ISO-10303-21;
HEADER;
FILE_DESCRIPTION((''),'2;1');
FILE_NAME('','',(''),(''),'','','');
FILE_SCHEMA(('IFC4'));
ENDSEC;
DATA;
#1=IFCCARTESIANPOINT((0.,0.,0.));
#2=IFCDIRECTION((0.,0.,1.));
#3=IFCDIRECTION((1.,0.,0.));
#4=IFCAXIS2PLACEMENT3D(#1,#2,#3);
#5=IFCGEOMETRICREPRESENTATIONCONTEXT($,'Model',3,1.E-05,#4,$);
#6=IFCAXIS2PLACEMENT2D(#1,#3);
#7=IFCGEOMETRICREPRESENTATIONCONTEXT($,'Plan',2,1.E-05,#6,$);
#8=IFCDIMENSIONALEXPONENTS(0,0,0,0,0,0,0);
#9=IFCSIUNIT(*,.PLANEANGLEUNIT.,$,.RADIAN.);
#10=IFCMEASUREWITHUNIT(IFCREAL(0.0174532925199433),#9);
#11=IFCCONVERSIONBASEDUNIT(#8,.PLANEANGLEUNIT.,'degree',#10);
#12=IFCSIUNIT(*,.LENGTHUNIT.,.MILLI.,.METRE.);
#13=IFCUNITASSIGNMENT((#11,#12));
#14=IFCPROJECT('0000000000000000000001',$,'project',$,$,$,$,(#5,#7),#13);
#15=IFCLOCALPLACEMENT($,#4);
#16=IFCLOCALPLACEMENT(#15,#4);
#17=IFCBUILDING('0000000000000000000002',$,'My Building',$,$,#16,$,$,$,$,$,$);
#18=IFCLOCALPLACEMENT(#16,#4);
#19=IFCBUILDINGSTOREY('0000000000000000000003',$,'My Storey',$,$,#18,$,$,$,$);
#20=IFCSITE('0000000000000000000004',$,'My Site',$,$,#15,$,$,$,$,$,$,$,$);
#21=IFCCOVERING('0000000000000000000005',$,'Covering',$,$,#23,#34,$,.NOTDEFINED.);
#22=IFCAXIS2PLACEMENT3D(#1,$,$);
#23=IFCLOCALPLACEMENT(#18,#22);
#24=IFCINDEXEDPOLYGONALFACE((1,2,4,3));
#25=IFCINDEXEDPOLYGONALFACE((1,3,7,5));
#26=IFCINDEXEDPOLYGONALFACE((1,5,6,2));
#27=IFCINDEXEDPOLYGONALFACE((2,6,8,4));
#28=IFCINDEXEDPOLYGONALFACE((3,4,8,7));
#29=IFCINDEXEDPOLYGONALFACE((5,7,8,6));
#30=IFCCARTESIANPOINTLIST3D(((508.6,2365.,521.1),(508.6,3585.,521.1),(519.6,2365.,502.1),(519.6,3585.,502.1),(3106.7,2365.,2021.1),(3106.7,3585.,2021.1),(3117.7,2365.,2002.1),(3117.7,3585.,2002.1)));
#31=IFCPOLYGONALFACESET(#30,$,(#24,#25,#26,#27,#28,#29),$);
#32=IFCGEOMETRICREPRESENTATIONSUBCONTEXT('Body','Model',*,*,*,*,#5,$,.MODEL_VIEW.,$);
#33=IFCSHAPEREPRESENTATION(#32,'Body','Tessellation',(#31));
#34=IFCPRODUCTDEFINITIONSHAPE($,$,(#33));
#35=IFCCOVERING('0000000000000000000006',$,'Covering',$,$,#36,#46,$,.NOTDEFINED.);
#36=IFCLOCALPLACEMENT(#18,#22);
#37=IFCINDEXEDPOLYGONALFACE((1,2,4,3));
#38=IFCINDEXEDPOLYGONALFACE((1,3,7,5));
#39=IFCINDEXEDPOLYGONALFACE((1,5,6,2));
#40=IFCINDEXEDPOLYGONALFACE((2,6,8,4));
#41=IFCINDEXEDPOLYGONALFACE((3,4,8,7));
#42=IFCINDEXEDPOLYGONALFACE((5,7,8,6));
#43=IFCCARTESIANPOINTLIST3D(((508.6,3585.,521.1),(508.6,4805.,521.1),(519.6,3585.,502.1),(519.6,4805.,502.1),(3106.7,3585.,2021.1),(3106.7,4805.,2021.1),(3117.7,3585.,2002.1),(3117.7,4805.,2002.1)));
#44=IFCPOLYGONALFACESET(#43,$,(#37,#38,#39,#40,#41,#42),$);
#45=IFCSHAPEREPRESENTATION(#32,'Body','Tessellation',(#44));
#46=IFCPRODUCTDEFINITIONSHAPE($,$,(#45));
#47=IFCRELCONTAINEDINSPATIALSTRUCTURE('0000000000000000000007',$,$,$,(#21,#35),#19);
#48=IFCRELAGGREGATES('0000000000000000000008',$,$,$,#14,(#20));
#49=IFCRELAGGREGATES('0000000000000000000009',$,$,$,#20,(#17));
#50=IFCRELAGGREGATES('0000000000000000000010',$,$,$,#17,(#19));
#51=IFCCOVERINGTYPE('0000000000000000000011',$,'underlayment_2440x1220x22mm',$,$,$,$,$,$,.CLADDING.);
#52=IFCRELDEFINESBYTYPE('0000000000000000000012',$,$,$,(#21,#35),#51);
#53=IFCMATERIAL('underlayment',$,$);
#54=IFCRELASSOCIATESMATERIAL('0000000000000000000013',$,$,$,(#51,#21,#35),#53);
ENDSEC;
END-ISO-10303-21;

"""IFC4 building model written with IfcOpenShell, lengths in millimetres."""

from ifc_helpers import new_model, entity, si_unit, converted_unit, frame, frame_2d, origin_with_axes, place, context, subcontext, project, spatial, rectangle, extrude, material, material_profile, profile_set, profile_usage, type_object, element, save


model = new_model("IFC4")

# Units and contexts
model_context = context("Model", 3, precision=1e-05, world=origin_with_axes())
plan_context = context("Plan", 2, precision=1e-05, world=frame_2d((0.0, 0.0, 0.0), x_axis=(1.0, 0.0, 0.0)))
body_context = subcontext(model_context, "Body", "Model", "MODEL_VIEW")
ifc_project = project(units=[converted_unit("PLANEANGLEUNIT", "degree", entity("IfcReal", 0.0174532925199433), si_unit("PLANEANGLEUNIT", "RADIAN"), dimensions=[0, 0, 0, 0, 0, 0, 0]), si_unit("LENGTHUNIT", "METRE", prefix="MILLI")], contexts=[model_context, plan_context])

# Site, building, storey
site_placement = place(None, origin_with_axes())
site = spatial("IfcSite", under=ifc_project, at=site_placement, Name="My Site")
building_placement = place(site_placement, origin_with_axes())
building = spatial("IfcBuilding", under=site, at=building_placement, Name="My Building")
storey_placement = place(building_placement, origin_with_axes())
storey = spatial("IfcBuildingStorey", under=building, at=storey_placement, Name="My Storey")

# Coverings
ifc_material_1 = material(Name="underlayment")
ifc_material_profile_1 = material_profile(ifc_material_1, rectangle(XDim=1220.0, YDim=22.0))
ifc_profile_set_1 = profile_set([ifc_material_profile_1])
covering_type = type_object("IfcCoveringType", Name="underlayment_2440x1220x22mm", PredefinedType="CLADDING", material=ifc_profile_set_1)
ifc_profile_usage_1 = profile_usage(ifc_profile_set_1, cardinal=1)
covering_1_placement = place(storey_placement, frame((519.6, 3585.0, 502.1), z_axis=(0.866026, 0.0, 0.5), x_axis=(0.0, 1.0, 0.0)))
element("IfcCovering", 1, at=covering_1_placement, inside=storey, type_object=covering_type, material=ifc_profile_usage_1, Name="Covering", PredefinedType="NOTDEFINED", context=body_context, shape_type="SweptSolid", body=[
    extrude(rectangle(XDim=1220.0, YDim=22.0), frame((-610.0, 11.0, 0.0), z_axis=(0.0, 0.0, 1.0), x_axis=(1.0, 0.0, 0.0)), (0.0, 0.0, 1.0), 3000.0),
])
ifc_profile_usage_2 = profile_usage(ifc_profile_set_1, cardinal=1)
covering_2_placement = place(storey_placement, frame((519.6, 4805.0, 502.1), z_axis=(0.866026, 0.0, 0.5), x_axis=(0.0, 1.0, 0.0)))
element("IfcCovering", 2, at=covering_2_placement, inside=storey, type_object=covering_type, material=ifc_profile_usage_2, Name="Covering", PredefinedType="NOTDEFINED", context=body_context, shape_type="SweptSolid", body=[
    extrude(rectangle(XDim=1220.0, YDim=22.0), frame((-610.0, 11.0, 0.0), z_axis=(0.0, 0.0, 1.0), x_axis=(1.0, 0.0, 0.0)), (0.0, 0.0, 1.0), 3000.0),
])

save(model, "model.ifc")
